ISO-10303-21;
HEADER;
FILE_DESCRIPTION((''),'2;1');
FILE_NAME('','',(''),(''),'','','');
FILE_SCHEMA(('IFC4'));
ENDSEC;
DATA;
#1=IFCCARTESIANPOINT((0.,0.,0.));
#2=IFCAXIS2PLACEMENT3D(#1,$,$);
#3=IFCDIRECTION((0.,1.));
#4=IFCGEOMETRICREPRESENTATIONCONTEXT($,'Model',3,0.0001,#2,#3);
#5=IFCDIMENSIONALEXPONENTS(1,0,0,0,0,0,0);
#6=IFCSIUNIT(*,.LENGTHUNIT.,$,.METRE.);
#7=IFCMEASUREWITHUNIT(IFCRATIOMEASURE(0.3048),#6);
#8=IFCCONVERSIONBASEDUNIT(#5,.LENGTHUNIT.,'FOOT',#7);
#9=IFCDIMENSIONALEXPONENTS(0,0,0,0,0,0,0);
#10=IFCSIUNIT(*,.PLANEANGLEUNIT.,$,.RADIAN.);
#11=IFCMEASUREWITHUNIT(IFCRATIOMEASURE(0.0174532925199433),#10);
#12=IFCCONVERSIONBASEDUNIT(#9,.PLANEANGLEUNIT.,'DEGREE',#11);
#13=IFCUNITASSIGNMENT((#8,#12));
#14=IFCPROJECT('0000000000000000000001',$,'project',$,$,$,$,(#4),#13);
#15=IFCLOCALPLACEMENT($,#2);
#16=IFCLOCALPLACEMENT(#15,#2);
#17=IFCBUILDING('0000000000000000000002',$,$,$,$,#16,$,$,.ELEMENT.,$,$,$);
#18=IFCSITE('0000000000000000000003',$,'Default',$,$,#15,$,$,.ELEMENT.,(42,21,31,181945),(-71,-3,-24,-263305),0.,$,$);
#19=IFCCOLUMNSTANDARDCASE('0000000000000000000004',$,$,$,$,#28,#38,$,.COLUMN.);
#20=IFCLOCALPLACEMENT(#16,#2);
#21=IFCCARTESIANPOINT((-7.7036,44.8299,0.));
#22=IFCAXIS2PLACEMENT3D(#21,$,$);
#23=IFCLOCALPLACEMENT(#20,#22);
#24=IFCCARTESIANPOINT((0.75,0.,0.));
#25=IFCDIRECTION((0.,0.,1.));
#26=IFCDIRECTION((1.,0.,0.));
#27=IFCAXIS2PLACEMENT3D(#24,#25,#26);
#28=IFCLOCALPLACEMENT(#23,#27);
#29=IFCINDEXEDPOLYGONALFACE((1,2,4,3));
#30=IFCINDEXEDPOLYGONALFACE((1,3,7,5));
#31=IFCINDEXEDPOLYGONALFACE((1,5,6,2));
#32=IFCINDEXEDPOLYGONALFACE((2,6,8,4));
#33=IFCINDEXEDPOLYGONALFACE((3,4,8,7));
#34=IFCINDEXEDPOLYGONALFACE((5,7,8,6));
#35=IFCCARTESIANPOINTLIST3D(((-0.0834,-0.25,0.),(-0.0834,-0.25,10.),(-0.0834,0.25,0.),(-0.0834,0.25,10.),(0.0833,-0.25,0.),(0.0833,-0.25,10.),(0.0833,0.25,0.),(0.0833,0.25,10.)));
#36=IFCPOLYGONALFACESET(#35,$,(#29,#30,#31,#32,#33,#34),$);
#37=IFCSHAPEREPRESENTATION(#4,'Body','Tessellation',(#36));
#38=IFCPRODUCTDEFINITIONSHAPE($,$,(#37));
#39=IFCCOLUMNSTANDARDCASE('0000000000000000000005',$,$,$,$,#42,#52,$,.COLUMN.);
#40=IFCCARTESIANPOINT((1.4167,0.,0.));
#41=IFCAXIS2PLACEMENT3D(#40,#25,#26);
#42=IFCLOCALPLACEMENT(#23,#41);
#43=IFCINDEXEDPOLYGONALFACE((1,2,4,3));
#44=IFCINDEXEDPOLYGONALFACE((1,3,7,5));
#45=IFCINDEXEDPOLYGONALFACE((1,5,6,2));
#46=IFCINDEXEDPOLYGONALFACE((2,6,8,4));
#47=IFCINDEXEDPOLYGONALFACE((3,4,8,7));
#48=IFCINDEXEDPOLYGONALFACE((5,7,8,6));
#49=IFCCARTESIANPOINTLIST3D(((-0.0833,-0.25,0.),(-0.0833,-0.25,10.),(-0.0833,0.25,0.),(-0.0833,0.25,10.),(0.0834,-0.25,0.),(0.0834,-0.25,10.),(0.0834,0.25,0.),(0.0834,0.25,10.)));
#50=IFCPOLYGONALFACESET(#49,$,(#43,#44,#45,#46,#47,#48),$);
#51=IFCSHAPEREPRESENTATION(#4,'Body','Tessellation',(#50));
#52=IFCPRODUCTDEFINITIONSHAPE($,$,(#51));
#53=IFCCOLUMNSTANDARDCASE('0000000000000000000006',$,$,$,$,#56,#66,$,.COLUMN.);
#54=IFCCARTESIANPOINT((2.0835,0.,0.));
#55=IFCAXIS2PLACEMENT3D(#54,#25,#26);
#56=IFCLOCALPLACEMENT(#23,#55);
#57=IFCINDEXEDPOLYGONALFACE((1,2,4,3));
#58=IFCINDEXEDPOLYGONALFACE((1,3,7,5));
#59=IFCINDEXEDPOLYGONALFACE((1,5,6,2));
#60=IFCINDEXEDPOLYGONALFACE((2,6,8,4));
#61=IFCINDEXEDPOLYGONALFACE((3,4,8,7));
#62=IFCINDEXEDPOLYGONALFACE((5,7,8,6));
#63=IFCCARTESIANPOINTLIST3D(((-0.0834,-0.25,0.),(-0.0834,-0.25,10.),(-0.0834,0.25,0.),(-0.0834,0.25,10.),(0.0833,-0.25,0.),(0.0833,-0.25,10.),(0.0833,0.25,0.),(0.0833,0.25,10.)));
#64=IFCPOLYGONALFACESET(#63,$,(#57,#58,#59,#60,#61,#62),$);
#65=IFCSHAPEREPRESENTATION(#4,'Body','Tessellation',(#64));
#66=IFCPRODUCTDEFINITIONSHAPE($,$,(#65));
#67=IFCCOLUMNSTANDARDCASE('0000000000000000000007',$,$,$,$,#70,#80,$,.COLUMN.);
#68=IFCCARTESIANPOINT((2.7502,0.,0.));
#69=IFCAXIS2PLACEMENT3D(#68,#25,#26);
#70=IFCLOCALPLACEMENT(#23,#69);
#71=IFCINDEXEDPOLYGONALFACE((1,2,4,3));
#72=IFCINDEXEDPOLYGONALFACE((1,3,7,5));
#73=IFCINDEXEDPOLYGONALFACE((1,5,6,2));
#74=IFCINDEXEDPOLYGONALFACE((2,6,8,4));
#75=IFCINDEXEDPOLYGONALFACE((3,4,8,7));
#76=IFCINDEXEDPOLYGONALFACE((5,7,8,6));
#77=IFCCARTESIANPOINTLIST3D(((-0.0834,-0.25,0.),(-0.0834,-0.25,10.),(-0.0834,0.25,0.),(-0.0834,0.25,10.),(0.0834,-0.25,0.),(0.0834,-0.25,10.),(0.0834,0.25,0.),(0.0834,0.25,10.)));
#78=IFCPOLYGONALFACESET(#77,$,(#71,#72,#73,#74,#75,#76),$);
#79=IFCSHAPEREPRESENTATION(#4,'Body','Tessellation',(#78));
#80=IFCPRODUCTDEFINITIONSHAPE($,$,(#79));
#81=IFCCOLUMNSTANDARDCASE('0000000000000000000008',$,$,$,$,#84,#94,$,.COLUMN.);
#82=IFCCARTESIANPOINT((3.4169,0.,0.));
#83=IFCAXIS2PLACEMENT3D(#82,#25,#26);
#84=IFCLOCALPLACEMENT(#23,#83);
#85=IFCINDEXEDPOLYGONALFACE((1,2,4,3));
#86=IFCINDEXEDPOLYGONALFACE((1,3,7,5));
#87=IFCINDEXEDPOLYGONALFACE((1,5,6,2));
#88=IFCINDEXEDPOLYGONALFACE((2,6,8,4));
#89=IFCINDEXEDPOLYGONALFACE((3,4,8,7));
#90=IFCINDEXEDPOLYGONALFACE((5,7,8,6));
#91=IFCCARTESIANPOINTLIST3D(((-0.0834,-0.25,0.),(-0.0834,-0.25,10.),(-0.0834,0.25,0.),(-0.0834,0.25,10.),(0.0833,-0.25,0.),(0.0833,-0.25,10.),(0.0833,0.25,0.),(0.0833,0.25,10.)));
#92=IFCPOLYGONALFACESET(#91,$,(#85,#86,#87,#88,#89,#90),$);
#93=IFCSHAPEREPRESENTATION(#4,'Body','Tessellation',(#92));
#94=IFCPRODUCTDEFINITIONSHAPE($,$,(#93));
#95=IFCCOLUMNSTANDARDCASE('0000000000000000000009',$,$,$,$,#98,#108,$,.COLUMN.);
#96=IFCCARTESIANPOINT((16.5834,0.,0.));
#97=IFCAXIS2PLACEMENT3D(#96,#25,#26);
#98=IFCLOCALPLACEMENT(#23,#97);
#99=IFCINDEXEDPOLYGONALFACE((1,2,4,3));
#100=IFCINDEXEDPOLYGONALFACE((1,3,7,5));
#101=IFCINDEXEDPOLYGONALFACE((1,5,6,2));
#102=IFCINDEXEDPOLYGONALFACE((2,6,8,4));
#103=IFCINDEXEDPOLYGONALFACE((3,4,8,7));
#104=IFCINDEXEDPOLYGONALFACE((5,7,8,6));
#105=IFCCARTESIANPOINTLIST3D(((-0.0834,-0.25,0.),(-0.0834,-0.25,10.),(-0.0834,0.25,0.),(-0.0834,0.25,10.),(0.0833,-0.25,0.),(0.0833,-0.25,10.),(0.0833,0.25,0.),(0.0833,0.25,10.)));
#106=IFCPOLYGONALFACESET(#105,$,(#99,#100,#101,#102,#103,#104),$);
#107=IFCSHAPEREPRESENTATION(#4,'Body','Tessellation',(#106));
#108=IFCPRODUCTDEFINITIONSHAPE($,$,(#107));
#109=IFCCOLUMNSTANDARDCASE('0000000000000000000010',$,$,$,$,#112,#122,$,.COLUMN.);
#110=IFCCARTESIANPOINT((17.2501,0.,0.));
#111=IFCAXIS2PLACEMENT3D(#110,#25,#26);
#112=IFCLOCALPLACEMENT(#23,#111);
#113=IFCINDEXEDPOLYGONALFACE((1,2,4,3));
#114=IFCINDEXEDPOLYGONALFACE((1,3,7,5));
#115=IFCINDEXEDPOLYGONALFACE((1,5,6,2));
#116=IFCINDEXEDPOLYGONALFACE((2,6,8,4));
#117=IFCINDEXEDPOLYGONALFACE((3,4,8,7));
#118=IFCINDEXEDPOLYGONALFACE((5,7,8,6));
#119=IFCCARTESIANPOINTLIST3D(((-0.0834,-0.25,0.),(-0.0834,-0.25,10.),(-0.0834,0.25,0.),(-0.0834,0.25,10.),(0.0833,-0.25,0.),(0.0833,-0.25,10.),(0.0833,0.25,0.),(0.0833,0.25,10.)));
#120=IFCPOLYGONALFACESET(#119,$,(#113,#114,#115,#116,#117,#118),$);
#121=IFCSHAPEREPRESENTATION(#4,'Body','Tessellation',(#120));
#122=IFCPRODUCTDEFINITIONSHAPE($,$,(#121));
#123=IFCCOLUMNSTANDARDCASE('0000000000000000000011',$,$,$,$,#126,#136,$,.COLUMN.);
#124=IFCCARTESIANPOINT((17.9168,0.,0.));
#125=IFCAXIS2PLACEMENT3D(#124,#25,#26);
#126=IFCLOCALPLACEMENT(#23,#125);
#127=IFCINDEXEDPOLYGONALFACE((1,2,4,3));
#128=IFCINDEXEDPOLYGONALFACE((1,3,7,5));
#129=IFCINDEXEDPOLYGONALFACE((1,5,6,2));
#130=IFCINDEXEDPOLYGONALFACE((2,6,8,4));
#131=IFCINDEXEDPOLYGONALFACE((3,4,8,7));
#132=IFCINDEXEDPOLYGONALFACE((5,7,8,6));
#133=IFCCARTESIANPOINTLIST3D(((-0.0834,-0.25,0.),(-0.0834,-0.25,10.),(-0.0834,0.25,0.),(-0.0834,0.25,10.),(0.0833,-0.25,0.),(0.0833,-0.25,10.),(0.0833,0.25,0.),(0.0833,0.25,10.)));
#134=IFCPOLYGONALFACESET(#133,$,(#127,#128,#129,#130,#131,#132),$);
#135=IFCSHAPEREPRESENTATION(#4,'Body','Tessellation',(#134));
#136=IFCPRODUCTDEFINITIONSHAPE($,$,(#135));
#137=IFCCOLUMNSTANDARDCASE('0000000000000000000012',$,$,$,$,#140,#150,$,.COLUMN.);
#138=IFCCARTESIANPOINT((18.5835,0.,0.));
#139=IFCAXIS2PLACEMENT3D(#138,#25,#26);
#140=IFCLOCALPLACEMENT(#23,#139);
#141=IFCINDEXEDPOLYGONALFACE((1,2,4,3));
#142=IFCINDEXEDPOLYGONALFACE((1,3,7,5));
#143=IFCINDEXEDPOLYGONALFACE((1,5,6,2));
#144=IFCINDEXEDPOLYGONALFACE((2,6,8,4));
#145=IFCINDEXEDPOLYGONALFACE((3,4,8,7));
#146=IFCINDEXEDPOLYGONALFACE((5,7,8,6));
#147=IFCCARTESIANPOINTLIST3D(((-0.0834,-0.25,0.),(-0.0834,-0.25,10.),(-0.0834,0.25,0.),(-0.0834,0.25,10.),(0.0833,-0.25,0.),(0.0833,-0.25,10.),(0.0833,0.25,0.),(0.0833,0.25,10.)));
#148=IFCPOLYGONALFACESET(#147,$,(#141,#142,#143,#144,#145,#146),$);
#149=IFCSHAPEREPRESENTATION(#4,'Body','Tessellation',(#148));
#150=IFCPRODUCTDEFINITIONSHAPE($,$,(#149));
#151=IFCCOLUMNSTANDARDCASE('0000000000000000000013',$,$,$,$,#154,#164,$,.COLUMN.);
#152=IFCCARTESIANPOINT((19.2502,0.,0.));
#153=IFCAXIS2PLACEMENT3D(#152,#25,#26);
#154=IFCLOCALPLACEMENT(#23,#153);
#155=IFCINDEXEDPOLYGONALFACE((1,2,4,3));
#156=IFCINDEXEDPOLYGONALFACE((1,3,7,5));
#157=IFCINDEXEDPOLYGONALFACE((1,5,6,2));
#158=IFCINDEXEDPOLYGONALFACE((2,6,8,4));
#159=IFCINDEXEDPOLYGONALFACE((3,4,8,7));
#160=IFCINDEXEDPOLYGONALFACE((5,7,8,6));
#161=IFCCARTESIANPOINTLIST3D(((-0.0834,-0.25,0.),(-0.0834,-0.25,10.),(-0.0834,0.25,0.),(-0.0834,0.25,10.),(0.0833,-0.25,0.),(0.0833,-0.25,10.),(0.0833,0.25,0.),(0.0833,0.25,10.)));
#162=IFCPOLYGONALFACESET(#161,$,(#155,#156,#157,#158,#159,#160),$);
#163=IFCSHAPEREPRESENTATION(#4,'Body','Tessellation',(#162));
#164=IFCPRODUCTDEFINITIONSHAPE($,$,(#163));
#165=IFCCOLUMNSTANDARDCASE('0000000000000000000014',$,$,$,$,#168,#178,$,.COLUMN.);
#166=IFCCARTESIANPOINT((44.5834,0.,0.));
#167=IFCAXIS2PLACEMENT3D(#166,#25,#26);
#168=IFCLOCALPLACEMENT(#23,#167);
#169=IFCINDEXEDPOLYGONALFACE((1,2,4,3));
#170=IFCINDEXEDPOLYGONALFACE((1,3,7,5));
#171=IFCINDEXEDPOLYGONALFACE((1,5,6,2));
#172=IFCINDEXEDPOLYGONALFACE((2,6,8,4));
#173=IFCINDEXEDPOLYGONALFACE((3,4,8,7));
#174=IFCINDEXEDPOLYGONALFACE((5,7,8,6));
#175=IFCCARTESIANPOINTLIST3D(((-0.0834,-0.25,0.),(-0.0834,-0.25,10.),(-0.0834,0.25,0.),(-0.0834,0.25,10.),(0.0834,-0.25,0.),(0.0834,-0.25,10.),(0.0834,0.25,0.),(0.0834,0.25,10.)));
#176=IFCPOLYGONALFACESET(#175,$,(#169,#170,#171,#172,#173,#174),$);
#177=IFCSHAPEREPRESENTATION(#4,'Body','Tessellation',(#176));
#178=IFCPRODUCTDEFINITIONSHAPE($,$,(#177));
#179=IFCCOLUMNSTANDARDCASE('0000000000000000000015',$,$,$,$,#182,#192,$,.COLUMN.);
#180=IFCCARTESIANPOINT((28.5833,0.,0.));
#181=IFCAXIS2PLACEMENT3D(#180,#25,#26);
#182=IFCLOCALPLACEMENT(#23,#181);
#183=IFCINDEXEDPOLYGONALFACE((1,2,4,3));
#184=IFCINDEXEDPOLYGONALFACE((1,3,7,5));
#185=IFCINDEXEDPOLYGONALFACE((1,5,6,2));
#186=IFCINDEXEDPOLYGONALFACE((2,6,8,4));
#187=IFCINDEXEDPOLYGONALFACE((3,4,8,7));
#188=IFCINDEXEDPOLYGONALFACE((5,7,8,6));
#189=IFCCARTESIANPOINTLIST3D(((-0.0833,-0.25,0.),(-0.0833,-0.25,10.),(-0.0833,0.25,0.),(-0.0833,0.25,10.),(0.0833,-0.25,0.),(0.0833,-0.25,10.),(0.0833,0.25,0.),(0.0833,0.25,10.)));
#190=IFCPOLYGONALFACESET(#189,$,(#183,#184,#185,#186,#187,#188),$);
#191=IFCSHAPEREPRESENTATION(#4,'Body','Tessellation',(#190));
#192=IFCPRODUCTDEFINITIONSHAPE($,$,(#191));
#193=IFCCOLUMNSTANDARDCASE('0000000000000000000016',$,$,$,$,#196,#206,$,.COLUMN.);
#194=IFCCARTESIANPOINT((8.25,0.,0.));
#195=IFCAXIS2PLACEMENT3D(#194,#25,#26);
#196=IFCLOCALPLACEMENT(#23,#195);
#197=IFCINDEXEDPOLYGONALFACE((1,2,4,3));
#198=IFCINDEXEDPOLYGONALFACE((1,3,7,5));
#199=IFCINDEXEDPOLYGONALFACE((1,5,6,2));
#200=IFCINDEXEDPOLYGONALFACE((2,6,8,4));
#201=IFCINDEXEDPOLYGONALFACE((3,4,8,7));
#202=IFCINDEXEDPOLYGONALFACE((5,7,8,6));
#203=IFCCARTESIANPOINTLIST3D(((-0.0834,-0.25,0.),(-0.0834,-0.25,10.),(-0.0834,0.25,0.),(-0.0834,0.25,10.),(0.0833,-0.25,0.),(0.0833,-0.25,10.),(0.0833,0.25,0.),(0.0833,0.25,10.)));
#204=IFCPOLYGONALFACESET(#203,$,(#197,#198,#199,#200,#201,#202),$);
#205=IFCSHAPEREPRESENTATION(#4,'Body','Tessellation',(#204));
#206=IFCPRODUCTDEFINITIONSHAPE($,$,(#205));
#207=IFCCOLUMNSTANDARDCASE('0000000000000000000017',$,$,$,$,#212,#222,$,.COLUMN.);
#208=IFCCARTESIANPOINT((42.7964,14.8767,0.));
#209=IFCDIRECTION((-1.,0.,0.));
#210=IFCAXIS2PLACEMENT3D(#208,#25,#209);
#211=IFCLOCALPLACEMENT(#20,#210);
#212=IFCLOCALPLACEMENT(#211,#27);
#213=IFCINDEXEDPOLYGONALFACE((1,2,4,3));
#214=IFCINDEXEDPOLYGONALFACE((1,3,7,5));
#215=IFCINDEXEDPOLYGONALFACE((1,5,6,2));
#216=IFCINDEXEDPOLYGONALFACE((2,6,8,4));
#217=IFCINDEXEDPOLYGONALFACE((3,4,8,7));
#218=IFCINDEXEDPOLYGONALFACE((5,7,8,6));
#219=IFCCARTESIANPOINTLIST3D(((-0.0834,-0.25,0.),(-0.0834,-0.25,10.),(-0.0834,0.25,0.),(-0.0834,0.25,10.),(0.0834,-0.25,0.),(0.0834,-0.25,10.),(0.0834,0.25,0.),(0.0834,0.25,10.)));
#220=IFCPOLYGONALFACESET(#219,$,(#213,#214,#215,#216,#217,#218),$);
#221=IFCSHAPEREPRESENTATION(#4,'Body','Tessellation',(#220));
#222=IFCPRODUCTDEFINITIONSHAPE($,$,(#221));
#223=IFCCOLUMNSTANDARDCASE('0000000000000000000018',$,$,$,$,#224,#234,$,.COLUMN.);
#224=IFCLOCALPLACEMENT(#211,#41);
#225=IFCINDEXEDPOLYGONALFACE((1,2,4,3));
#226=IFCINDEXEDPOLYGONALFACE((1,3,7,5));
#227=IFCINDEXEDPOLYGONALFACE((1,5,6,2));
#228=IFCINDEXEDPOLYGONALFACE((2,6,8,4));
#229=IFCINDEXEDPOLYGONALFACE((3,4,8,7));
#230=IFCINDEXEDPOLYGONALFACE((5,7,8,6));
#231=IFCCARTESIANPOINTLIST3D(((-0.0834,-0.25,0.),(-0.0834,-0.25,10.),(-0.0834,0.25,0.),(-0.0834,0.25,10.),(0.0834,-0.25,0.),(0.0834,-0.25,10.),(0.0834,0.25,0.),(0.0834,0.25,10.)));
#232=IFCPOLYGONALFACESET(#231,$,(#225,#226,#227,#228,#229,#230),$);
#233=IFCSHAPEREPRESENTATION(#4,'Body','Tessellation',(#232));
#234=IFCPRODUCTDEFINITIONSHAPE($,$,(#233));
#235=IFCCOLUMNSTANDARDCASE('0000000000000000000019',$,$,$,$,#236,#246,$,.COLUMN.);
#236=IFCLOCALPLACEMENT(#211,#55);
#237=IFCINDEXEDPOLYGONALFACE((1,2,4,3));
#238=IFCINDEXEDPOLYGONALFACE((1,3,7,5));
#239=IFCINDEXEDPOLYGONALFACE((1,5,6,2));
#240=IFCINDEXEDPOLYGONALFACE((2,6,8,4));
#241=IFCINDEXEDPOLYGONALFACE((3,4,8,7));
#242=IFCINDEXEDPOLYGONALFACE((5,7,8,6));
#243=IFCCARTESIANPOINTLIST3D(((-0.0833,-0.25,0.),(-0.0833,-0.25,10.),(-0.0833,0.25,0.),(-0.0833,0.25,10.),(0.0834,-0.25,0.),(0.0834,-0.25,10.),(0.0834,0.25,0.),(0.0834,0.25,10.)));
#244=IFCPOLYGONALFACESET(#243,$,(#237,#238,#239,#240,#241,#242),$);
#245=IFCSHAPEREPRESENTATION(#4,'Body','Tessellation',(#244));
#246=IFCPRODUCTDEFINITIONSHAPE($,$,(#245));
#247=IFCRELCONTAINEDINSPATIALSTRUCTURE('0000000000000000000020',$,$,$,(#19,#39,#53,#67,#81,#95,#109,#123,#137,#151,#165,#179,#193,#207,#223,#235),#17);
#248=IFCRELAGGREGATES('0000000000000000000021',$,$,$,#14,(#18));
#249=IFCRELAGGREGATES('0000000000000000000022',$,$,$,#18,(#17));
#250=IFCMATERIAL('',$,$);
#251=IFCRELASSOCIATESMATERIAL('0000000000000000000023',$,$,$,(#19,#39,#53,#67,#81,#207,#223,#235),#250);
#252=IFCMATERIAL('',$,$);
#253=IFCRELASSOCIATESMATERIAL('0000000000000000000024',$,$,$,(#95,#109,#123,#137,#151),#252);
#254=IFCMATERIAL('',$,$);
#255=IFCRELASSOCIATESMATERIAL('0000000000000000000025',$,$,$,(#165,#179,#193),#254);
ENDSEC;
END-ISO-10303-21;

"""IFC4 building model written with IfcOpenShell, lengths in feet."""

from ifc_helpers import new_model, entity, si_unit, converted_unit, direction, frame, origin, place, context, project, spatial, rectangle, extrude, material, element, save


model = new_model("IFC4")

# Units and contexts
model_context = context("Model", 3, precision=0.0001, world=origin(), true_north=direction((0.0, 1.0)))
ifc_project = project(units=[converted_unit("LENGTHUNIT", "FOOT", entity("IfcRatioMeasure", 0.3048), si_unit("LENGTHUNIT", "METRE"), dimensions=[1, 0, 0, 0, 0, 0, 0]), converted_unit("PLANEANGLEUNIT", "DEGREE", entity("IfcRatioMeasure", 0.0174532925199433), si_unit("PLANEANGLEUNIT", "RADIAN"), dimensions=[0, 0, 0, 0, 0, 0, 0])], contexts=[model_context])

# Site, building
site_placement = place(None, origin())
site = spatial("IfcSite", under=ifc_project, at=site_placement, Name="Default", CompositionType="ELEMENT", RefLatitude=(42, 21, 31, 181945), RefLongitude=(-71, -3, -24, -263305), RefElevation=0.0)
building_placement = place(site_placement, origin())
building = spatial("IfcBuilding", under=site, at=building_placement, CompositionType="ELEMENT")

# Columns
ifc_material_1 = material(Name="")
placement_1 = place(building_placement, origin())
placement_2 = place(placement_1, frame((-7.7036, 44.8299, 0.0)))
for number, where, z_axis, x_axis in (
    (1, (0.75, 0.0, 0.0), (0.0, 0.0, 1.0), (1.0, 0.0, 0.0)),
    (2, (1.4167, 0.0, 0.0), (0.0, 0.0, 1.0), (1.0, 0.0, 0.0)),
    (3, (2.0835, 0.0, 0.0), (0.0, 0.0, 1.0), (1.0, 0.0, 0.0)),
    (4, (2.7502, 0.0, 0.0), (0.0, 0.0, 1.0), (1.0, 0.0, 0.0)),
    (5, (3.4169, 0.0, 0.0), (0.0, 0.0, 1.0), (1.0, 0.0, 0.0)),
):
    element("IfcColumnStandardCase", number, at=place(placement_2, frame(where, z_axis=z_axis, x_axis=x_axis)), inside=building, material=ifc_material_1, PredefinedType="COLUMN", context=model_context, shape_type="SweptSolid", body=[
        extrude(rectangle(XDim=0.1667, YDim=0.5), origin(), (0.0, 0.0, 1.0), 10.0),
    ])
ifc_material_2 = material(Name="")
for number, where, z_axis, x_axis in (
    (6, (16.5834, 0.0, 0.0), (0.0, 0.0, 1.0), (1.0, 0.0, 0.0)),
    (7, (17.2501, 0.0, 0.0), (0.0, 0.0, 1.0), (1.0, 0.0, 0.0)),
    (8, (17.9168, 0.0, 0.0), (0.0, 0.0, 1.0), (1.0, 0.0, 0.0)),
    (9, (18.5835, 0.0, 0.0), (0.0, 0.0, 1.0), (1.0, 0.0, 0.0)),
    (10, (19.2502, 0.0, 0.0), (0.0, 0.0, 1.0), (1.0, 0.0, 0.0)),
):
    element("IfcColumnStandardCase", number, at=place(placement_2, frame(where, z_axis=z_axis, x_axis=x_axis)), inside=building, material=ifc_material_2, PredefinedType="COLUMN", context=model_context, shape_type="SweptSolid", body=[
        extrude(rectangle(XDim=0.1667, YDim=0.5), origin(), (0.0, 0.0, 1.0), 10.0),
    ])
ifc_material_3 = material(Name="")
for number, where, z_axis, x_axis in (
    (11, (44.5834, 0.0, 0.0), (0.0, 0.0, 1.0), (1.0, 0.0, 0.0)),
    (12, (28.5833, 0.0, 0.0), (0.0, 0.0, 1.0), (1.0, 0.0, 0.0)),
    (13, (8.25, 0.0, 0.0), (0.0, 0.0, 1.0), (1.0, 0.0, 0.0)),
):
    element("IfcColumnStandardCase", number, at=place(placement_2, frame(where, z_axis=z_axis, x_axis=x_axis)), inside=building, material=ifc_material_3, PredefinedType="COLUMN", context=model_context, shape_type="SweptSolid", body=[
        extrude(rectangle(XDim=0.1667, YDim=0.5), origin(), (0.0, 0.0, 1.0), 10.0),
    ])
placement_3 = place(placement_1, frame((42.7964, 14.8767, 0.0), z_axis=(0.0, 0.0, 1.0), x_axis=(-1.0, 0.0, 0.0)))
for number, where, z_axis, x_axis in (
    (14, (0.75, 0.0, 0.0), (0.0, 0.0, 1.0), (1.0, 0.0, 0.0)),
    (15, (1.4167, 0.0, 0.0), (0.0, 0.0, 1.0), (1.0, 0.0, 0.0)),
    (16, (2.0835, 0.0, 0.0), (0.0, 0.0, 1.0), (1.0, 0.0, 0.0)),
):
    element("IfcColumnStandardCase", number, at=place(placement_3, frame(where, z_axis=z_axis, x_axis=x_axis)), inside=building, material=ifc_material_1, PredefinedType="COLUMN", context=model_context, shape_type="SweptSolid", body=[
        extrude(rectangle(XDim=0.1667, YDim=0.5), origin(), (0.0, 0.0, 1.0), 10.0),
    ])

save(model, "model.ifc")
